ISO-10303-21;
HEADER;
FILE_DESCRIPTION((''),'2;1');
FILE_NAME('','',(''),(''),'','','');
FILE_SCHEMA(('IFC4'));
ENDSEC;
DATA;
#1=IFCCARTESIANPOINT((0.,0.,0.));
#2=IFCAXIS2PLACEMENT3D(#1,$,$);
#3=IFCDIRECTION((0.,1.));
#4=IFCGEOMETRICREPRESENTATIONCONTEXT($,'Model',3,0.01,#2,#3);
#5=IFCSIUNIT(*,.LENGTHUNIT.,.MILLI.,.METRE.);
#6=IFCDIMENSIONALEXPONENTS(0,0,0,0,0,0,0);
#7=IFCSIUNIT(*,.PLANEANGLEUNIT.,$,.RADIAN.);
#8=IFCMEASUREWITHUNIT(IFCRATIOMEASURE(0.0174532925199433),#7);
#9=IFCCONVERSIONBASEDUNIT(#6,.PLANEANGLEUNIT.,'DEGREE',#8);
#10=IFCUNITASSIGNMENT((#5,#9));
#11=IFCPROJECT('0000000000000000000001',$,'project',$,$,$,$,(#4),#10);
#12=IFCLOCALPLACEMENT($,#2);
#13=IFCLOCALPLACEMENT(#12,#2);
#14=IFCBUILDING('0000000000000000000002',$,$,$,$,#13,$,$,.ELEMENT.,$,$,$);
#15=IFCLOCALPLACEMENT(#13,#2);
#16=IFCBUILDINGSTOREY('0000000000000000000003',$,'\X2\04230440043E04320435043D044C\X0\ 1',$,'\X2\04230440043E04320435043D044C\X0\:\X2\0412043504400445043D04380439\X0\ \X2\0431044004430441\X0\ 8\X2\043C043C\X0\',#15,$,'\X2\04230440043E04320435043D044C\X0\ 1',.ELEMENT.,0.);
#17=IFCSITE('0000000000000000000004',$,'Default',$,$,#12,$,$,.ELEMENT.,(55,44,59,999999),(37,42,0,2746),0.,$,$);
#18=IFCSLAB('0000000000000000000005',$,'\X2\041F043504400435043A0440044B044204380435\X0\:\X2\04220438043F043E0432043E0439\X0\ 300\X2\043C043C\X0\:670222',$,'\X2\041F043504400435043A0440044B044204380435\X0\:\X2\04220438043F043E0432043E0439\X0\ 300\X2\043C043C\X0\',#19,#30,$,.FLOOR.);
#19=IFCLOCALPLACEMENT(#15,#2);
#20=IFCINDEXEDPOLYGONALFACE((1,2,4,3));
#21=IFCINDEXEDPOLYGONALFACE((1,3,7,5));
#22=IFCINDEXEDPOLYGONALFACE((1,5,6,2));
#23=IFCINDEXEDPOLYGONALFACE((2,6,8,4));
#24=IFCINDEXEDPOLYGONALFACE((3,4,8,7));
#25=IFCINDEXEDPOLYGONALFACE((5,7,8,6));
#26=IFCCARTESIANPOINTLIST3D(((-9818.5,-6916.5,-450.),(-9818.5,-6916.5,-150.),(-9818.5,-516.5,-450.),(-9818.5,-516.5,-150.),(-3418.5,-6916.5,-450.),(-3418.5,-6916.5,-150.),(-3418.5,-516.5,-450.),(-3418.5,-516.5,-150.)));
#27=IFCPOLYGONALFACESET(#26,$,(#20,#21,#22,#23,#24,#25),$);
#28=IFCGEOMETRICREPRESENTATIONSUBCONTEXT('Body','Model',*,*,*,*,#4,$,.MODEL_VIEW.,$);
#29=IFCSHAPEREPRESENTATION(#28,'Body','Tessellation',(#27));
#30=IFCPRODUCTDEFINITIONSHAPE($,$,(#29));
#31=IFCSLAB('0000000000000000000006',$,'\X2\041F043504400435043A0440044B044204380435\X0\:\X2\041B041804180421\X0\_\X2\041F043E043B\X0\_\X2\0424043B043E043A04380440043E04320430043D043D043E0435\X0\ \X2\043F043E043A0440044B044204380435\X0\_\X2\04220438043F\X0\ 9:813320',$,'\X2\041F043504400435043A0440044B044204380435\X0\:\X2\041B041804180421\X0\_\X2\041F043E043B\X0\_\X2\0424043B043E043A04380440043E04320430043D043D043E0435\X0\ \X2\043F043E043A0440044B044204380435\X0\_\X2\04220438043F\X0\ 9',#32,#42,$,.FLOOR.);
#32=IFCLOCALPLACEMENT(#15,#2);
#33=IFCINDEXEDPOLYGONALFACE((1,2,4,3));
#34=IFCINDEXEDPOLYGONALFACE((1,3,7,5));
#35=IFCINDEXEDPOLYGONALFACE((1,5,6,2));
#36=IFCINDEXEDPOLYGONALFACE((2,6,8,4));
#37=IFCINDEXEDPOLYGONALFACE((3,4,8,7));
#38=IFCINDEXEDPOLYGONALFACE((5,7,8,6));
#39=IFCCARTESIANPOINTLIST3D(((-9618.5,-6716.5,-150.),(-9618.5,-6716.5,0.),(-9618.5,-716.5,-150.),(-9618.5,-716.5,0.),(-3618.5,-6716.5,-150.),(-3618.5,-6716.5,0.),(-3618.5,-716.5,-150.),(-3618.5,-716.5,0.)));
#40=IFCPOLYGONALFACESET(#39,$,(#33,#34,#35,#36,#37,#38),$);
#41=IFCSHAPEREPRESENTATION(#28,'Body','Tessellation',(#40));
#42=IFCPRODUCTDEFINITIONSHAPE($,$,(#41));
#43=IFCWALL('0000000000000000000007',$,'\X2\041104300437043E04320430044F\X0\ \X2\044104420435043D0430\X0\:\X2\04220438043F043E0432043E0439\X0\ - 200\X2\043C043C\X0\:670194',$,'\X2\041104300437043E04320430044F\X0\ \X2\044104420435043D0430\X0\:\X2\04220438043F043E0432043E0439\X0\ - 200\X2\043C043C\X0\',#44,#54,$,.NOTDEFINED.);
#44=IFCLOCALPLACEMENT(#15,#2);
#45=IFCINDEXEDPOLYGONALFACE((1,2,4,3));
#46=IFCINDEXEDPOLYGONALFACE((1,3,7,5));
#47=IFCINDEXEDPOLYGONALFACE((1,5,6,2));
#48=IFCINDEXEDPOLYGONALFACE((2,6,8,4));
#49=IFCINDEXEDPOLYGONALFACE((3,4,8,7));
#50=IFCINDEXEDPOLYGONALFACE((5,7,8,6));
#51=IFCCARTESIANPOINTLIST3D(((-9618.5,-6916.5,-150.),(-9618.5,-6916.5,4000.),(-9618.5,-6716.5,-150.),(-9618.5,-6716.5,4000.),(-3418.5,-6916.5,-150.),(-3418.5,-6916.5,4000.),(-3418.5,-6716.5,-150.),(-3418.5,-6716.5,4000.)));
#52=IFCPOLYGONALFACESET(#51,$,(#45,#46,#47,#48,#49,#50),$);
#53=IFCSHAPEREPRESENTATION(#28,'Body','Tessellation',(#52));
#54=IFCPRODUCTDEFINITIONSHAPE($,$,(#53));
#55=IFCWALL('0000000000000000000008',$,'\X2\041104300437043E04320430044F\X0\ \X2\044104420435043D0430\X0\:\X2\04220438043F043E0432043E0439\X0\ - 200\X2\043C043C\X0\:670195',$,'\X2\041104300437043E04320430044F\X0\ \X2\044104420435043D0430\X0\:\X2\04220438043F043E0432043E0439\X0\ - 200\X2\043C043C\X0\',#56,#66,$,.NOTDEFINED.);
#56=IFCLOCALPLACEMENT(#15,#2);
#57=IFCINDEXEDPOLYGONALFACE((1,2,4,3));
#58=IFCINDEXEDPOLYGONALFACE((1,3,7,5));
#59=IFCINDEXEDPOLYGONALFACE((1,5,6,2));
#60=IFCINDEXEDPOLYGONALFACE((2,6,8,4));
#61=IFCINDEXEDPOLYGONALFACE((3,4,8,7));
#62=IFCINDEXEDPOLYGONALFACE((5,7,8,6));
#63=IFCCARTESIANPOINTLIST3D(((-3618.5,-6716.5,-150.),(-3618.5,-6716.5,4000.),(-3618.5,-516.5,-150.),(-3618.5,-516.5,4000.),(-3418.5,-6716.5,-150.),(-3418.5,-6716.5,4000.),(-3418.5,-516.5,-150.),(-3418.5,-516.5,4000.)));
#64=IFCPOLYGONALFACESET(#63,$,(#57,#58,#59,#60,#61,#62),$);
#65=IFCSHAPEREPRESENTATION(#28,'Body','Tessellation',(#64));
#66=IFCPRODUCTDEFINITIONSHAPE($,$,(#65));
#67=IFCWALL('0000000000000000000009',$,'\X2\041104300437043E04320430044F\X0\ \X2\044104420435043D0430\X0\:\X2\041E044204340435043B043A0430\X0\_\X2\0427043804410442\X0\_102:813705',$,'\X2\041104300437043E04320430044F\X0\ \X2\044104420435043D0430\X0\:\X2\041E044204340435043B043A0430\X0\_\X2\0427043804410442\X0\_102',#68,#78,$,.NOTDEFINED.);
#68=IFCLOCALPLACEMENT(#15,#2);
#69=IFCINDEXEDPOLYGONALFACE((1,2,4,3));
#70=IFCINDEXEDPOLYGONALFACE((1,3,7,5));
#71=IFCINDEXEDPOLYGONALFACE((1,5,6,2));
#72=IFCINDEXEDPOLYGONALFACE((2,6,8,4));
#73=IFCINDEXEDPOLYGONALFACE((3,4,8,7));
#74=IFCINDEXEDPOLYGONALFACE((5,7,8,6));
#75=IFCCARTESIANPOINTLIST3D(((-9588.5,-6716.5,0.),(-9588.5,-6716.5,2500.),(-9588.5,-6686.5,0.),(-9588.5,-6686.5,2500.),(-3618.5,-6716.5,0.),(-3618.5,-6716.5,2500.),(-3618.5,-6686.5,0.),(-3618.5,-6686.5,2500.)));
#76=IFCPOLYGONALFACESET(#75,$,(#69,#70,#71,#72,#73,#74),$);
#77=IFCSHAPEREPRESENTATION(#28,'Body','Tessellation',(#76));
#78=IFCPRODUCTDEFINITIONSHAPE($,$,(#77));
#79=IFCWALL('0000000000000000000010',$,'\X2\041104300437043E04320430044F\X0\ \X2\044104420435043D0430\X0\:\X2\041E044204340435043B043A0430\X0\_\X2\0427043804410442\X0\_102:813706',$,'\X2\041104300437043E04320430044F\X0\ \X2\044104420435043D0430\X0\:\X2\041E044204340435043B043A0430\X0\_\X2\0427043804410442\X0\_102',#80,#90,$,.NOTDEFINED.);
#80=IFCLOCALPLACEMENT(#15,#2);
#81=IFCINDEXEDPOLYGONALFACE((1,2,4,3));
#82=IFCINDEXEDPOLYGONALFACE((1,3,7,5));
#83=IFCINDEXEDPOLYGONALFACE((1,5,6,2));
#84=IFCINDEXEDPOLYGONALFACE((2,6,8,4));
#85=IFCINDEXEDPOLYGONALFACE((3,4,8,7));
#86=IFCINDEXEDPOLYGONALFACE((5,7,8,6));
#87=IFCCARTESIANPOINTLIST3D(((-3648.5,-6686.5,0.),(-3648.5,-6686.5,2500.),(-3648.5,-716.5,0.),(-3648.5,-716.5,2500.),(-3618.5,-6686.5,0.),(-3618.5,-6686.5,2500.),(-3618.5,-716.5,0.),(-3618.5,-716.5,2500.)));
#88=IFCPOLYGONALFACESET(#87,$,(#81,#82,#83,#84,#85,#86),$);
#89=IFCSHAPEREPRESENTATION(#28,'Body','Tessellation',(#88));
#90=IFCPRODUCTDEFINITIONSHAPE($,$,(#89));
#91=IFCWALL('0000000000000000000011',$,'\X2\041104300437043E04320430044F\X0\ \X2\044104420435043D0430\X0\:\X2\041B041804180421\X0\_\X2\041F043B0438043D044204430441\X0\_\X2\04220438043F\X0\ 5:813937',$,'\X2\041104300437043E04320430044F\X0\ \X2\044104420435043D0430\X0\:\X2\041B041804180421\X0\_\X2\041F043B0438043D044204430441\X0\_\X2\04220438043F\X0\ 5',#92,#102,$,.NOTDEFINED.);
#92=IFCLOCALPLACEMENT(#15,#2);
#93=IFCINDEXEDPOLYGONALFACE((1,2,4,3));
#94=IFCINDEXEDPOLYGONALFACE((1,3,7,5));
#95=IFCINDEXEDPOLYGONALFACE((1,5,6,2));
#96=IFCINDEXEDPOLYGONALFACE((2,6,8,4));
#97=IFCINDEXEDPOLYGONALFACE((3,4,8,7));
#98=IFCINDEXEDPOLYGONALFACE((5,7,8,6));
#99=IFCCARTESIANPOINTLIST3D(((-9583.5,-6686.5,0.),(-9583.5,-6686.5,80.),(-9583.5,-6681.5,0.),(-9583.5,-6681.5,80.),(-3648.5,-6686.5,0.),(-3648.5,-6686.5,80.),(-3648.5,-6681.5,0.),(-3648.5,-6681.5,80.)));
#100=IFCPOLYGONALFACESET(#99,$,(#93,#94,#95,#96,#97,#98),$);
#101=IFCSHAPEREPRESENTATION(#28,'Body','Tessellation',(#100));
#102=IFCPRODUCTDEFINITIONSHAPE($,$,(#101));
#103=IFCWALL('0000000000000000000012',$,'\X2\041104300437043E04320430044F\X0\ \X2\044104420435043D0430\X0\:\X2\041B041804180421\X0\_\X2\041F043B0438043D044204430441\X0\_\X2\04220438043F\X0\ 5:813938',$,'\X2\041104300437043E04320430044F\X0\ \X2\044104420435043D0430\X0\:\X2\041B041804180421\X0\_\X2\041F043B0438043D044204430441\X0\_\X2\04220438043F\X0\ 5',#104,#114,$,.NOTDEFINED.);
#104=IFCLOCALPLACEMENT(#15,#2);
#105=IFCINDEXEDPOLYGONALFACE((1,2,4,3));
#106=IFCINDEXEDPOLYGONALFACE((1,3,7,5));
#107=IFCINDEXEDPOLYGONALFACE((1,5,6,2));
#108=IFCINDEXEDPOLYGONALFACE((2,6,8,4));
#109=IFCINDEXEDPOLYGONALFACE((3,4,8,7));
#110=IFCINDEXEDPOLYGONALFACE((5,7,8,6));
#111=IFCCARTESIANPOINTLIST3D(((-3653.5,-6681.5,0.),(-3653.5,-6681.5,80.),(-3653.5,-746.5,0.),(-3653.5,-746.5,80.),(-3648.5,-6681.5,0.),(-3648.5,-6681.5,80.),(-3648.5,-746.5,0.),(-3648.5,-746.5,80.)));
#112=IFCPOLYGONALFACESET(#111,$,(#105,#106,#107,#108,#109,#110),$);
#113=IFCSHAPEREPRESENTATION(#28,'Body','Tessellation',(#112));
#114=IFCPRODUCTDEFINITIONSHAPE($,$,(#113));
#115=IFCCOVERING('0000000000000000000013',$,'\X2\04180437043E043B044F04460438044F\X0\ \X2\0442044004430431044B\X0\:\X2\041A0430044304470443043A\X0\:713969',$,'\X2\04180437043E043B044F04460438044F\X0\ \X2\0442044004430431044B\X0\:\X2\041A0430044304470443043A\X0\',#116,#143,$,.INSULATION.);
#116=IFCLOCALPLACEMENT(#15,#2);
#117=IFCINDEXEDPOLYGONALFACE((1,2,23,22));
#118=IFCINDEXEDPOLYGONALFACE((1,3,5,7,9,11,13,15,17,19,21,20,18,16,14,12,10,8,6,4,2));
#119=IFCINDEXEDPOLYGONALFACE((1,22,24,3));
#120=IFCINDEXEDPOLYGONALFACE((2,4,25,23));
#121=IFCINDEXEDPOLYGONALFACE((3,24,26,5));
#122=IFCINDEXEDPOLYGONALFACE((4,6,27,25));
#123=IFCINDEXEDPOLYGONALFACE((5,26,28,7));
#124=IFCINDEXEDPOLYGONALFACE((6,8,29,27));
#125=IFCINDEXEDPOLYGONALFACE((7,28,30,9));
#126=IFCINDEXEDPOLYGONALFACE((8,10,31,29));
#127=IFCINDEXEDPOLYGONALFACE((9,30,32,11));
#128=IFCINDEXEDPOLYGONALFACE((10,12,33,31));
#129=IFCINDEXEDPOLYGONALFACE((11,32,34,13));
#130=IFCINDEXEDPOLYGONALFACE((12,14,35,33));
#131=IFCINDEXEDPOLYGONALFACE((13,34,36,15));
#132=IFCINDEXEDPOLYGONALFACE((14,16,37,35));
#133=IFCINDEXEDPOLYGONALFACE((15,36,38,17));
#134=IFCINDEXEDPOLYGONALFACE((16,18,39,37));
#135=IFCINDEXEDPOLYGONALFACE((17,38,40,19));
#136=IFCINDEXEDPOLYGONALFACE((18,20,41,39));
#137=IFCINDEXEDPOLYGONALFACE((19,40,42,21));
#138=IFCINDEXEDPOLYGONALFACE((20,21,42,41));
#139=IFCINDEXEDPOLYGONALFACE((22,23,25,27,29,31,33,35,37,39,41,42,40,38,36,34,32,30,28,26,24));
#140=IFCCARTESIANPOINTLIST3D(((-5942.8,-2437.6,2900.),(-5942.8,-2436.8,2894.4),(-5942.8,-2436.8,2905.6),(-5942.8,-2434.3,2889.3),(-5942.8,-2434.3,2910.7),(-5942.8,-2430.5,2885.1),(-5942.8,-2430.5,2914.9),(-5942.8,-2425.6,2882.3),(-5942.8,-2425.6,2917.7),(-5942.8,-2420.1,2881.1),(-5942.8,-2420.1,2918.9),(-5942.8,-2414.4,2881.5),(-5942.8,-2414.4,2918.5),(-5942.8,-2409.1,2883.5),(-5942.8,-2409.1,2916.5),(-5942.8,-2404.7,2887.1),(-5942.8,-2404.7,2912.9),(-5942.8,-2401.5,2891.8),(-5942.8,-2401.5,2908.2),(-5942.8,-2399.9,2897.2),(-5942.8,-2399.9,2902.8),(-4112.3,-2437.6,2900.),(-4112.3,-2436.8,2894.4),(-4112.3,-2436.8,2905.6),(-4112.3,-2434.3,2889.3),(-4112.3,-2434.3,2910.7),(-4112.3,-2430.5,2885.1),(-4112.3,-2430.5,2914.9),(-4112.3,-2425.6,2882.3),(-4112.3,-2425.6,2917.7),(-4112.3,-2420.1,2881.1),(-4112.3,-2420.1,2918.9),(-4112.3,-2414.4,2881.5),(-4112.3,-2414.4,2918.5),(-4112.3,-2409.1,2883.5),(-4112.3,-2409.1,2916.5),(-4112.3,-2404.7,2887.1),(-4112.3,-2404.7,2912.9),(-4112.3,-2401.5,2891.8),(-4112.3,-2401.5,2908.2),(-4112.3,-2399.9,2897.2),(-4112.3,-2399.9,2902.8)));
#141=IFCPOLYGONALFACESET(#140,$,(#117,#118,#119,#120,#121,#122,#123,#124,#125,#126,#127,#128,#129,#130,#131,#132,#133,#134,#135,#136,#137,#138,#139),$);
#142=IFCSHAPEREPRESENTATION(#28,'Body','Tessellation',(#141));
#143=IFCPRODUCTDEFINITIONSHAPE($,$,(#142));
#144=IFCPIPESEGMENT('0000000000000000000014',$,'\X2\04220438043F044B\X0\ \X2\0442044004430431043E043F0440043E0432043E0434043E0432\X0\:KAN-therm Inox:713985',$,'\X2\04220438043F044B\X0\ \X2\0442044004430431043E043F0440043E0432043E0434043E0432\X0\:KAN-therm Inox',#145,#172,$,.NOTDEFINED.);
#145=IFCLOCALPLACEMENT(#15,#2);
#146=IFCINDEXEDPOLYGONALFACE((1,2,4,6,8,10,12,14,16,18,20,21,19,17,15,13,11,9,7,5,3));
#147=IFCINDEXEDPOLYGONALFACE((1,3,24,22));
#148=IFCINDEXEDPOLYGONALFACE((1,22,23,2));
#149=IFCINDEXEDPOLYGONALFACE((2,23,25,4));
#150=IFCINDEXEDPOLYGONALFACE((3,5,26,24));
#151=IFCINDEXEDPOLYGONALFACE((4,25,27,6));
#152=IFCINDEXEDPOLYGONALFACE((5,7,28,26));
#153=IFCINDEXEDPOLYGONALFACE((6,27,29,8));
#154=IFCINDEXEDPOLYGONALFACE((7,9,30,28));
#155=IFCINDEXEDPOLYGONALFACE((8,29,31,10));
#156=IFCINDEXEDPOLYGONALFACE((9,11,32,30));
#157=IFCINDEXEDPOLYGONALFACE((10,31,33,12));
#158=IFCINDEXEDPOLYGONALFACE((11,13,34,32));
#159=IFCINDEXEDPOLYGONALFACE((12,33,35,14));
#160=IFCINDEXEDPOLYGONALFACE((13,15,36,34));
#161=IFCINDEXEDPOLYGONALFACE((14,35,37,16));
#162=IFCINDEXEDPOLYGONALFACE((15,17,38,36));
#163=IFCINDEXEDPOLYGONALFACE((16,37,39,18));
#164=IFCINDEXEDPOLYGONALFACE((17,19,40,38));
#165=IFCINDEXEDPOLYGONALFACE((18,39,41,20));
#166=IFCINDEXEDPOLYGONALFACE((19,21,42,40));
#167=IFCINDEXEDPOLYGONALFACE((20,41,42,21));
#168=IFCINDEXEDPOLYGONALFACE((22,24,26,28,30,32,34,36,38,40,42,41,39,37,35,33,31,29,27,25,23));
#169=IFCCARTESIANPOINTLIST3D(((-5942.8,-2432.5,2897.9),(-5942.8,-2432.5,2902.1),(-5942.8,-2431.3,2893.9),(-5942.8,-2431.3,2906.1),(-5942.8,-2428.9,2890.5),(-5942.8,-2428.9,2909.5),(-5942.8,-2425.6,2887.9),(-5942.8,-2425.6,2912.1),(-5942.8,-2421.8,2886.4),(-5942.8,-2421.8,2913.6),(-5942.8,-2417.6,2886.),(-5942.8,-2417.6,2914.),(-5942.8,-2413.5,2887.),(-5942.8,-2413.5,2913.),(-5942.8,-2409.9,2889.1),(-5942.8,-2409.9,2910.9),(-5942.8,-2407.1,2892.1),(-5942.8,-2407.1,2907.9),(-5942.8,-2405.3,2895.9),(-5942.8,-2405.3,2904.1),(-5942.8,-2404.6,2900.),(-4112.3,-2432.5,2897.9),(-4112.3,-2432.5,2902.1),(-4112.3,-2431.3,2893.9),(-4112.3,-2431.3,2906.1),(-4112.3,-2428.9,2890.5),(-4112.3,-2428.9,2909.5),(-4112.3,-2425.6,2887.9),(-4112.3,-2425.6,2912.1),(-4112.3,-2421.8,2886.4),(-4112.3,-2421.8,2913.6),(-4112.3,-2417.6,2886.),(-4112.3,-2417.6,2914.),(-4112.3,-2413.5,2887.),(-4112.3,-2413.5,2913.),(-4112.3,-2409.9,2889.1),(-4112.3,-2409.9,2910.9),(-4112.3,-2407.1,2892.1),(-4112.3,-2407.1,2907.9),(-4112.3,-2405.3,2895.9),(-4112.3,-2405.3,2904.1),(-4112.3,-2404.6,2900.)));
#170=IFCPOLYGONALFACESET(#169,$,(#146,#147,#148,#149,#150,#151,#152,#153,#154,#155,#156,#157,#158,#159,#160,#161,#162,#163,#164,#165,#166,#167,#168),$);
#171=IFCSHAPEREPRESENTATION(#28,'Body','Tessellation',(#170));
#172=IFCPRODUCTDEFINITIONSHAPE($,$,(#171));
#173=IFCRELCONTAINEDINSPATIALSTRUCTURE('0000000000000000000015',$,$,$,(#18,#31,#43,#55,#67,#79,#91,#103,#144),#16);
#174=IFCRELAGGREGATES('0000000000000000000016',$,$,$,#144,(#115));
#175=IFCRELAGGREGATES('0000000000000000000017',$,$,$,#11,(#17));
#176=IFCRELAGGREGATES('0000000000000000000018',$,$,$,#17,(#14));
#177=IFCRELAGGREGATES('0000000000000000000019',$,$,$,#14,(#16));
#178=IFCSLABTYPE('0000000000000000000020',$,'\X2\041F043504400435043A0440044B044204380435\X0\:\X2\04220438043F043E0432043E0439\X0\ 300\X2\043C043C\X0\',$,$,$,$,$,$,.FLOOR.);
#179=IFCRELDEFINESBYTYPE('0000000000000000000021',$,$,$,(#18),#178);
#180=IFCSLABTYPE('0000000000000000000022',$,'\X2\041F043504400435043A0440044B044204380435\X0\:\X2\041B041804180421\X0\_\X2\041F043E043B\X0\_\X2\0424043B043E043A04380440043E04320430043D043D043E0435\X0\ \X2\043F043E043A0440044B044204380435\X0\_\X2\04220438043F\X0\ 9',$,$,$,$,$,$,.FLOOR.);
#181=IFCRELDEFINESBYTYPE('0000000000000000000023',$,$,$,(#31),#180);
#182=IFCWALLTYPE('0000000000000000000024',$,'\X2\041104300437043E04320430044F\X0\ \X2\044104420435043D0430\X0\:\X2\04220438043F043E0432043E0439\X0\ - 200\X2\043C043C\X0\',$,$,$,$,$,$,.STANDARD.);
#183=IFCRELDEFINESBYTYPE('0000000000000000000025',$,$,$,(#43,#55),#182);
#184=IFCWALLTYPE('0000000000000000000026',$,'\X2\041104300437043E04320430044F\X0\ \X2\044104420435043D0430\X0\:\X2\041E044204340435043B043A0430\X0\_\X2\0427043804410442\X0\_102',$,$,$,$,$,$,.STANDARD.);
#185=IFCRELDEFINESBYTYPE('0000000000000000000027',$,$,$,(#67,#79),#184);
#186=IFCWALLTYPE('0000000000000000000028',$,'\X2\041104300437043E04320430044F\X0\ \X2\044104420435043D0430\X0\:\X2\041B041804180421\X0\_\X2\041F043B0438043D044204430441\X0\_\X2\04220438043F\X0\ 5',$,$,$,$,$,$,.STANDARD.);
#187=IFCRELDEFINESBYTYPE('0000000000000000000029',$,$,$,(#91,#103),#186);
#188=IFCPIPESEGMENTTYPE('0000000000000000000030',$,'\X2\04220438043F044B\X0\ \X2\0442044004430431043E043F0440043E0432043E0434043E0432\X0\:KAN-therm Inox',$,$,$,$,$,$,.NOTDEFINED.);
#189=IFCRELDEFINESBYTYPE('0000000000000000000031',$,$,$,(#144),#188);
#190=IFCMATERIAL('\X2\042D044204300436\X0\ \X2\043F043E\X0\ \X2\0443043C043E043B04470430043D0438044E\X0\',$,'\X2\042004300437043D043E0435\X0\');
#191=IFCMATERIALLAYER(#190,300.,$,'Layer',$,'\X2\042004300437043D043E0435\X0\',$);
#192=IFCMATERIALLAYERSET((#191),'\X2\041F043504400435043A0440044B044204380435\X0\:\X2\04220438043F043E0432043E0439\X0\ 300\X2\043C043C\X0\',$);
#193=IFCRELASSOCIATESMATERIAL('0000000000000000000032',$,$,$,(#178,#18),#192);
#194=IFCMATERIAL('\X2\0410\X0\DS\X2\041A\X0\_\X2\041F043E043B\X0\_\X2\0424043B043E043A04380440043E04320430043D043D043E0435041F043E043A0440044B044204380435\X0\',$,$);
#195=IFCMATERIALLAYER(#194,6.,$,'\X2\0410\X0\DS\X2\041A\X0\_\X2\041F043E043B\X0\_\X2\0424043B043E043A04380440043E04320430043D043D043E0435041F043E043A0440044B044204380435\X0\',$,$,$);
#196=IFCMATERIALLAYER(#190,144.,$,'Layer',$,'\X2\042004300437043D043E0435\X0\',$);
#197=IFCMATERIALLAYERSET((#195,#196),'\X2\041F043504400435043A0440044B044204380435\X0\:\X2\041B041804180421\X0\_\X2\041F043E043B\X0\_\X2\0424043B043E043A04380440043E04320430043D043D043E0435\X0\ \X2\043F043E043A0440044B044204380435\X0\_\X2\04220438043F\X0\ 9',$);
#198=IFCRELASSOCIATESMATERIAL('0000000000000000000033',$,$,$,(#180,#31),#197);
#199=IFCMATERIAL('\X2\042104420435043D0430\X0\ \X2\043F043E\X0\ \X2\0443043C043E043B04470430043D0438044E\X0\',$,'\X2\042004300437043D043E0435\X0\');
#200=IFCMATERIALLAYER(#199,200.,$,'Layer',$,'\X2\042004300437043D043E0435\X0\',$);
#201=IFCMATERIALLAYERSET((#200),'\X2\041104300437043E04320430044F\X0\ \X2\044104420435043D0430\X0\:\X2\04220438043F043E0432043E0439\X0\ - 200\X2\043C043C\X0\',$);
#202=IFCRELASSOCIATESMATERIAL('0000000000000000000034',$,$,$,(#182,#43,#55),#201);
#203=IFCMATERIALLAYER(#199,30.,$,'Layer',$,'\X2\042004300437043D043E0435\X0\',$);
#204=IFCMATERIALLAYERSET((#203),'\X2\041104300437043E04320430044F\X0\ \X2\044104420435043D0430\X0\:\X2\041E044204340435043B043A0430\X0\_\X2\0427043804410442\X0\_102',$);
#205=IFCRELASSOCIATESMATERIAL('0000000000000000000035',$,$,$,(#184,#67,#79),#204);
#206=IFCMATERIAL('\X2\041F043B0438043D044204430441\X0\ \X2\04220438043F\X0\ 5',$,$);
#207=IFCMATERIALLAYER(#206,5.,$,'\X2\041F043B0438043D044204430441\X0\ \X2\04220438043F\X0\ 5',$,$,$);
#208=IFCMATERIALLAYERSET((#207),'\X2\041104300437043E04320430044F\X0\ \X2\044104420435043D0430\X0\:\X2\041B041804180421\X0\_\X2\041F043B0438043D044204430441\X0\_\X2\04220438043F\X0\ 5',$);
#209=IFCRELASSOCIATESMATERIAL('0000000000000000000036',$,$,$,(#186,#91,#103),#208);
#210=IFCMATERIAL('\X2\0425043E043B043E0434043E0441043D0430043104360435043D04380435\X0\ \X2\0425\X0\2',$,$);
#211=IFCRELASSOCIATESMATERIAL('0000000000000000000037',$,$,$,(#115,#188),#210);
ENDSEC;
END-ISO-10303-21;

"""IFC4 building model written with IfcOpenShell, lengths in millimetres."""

from ifc_helpers import new_model, entity, si_unit, converted_unit, direction, frame, frame_2d, origin, origin_2d_with_axis, place, context, subcontext, project, spatial, rectangle, circle, extrude, material, layer, layer_set, layer_usage, type_object, element, aggregate, save


model = new_model("IFC4")

# Units and contexts
model_context = context("Model", 3, precision=0.01, world=origin(), true_north=direction((0.0, 1.0)))
body_context = subcontext(model_context, "Body", "Model", "MODEL_VIEW")
ifc_project = project(units=[si_unit("LENGTHUNIT", "METRE", prefix="MILLI"), converted_unit("PLANEANGLEUNIT", "DEGREE", entity("IfcRatioMeasure", 0.0174532925199433), si_unit("PLANEANGLEUNIT", "RADIAN"), dimensions=[0, 0, 0, 0, 0, 0, 0])], contexts=[model_context])

# Site, building, storey
site_placement = place(None, origin())
site = spatial("IfcSite", under=ifc_project, at=site_placement, Name="Default", CompositionType="ELEMENT", RefLatitude=(55, 44, 59, 999999), RefLongitude=(37, 42, 0, 2746), RefElevation=0.0)
building_placement = place(site_placement, origin())
building = spatial("IfcBuilding", under=site, at=building_placement, CompositionType="ELEMENT")
storey_placement = place(building_placement, origin())
storey = spatial("IfcBuildingStorey", under=building, at=storey_placement, Name="Уровень 1", ObjectType="Уровень:Верхний брус 8мм", LongName="Уровень 1", CompositionType="ELEMENT", Elevation=0.0)

# Slabs
ifc_material_1 = material(Name="Этаж по умолчанию", Category="Разное")
ifc_layer_1 = layer(ifc_material_1, 300.0, Name="Layer", Category="Разное")
ifc_layer_set_1 = layer_set([ifc_layer_1], Name="Перекрытие:Типовой 300мм")
ifc_layer_usage_1 = layer_usage(ifc_layer_set_1, "AXIS3", "POSITIVE", 0.0)
slab_type_1 = type_object("IfcSlabType", Name="Перекрытие:Типовой 300мм", PredefinedType="FLOOR", material=ifc_layer_set_1)
slab_1_placement = place(storey_placement, origin())
element("IfcSlab", 1, at=slab_1_placement, inside=storey, type_object=slab_type_1, material=ifc_layer_usage_1, Name="Перекрытие:Типовой 300мм:670222", ObjectType="Перекрытие:Типовой 300мм", PredefinedType="FLOOR", context=body_context, shape_type="SweptSolid", body=[
    extrude(rectangle(XDim=6400.0, YDim=6400.0, at=origin_2d_with_axis()), frame((-6618.5, -3716.5, -150.0), z_axis=(0.0, 0.0, -1.0), x_axis=(0.0, 1.0, 0.0)), (0.0, 0.0, 1.0), 300.0),
])
ifc_material_2 = material(Name="АDSК_Пол_ФлокированноеПокрытие")
ifc_layer_2 = layer(ifc_material_2, 6.0, Name="АDSК_Пол_ФлокированноеПокрытие")
ifc_layer_3 = layer(ifc_material_1, 144.0, Name="Layer", Category="Разное")
ifc_layer_set_2 = layer_set([ifc_layer_2, ifc_layer_3], Name="Перекрытие:ЛИИС_Пол_Флокированное покрытие_Тип 9")
ifc_layer_usage_2 = layer_usage(ifc_layer_set_2, "AXIS3", "POSITIVE", 0.0)
slab_type_2 = type_object("IfcSlabType", Name="Перекрытие:ЛИИС_Пол_Флокированное покрытие_Тип 9", PredefinedType="FLOOR", material=ifc_layer_set_2)
slab_2_placement = place(storey_placement, origin())
element("IfcSlab", 2, at=slab_2_placement, inside=storey, type_object=slab_type_2, material=ifc_layer_usage_2, Name="Перекрытие:ЛИИС_Пол_Флокированное покрытие_Тип 9:813320", ObjectType="Перекрытие:ЛИИС_Пол_Флокированное покрытие_Тип 9", PredefinedType="FLOOR", context=body_context, shape_type="SweptSolid", body=[
    extrude(rectangle(XDim=6000.0, YDim=6000.0, at=origin_2d_with_axis()), frame((-6618.5, -3716.5, 0.0), z_axis=(0.0, 0.0, -1.0), x_axis=(0.0, 1.0, 0.0)), (0.0, 0.0, 1.0), 150.0),
])

# Walls
ifc_material_3 = material(Name="Стена по умолчанию", Category="Разное")
ifc_layer_4 = layer(ifc_material_3, 200.0, Name="Layer", Category="Разное")
ifc_layer_set_3 = layer_set([ifc_layer_4], Name="Базовая стена:Типовой - 200мм")
ifc_layer_usage_3 = layer_usage(ifc_layer_set_3, "AXIS2", "NEGATIVE", 100.0)
wall_type_1 = type_object("IfcWallType", Name="Базовая стена:Типовой - 200мм", PredefinedType="STANDARD", material=ifc_layer_set_3)
wall_1_placement = place(storey_placement, frame((-3418.5, -6816.5, -150.0), z_axis=(0.0, 0.0, 1.0), x_axis=(-1.0, 0.0, 0.0)))
element("IfcWall", 3, at=wall_1_placement, inside=storey, type_object=wall_type_1, material=ifc_layer_usage_3, Name="Базовая стена:Типовой - 200мм:670194", ObjectType="Базовая стена:Типовой - 200мм", PredefinedType="NOTDEFINED", context=body_context, shape_type="SweptSolid", body=[
    extrude(rectangle(XDim=6200.0, YDim=200.0, at=frame_2d((3100.0, 0.0), x_axis=(-1.0, 0.0))), origin(), (0.0, 0.0, 1.0), 4150.0),
])
ifc_layer_usage_4 = layer_usage(ifc_layer_set_3, "AXIS2", "NEGATIVE", 100.0)
wall_2_placement = place(storey_placement, frame((-3518.5, -516.5, -150.0), z_axis=(0.0, 0.0, 1.0), x_axis=(0.0, -1.0, 0.0)))
element("IfcWall", 4, at=wall_2_placement, inside=storey, type_object=wall_type_1, material=ifc_layer_usage_4, Name="Базовая стена:Типовой - 200мм:670195", ObjectType="Базовая стена:Типовой - 200мм", PredefinedType="NOTDEFINED", context=body_context, shape_type="SweptSolid", body=[
    extrude(rectangle(XDim=6200.0, YDim=200.0, at=frame_2d((3100.0, 0.0), x_axis=(-1.0, 0.0))), origin(), (0.0, 0.0, 1.0), 4150.0),
])
ifc_layer_5 = layer(ifc_material_3, 30.0, Name="Layer", Category="Разное")
ifc_layer_set_4 = layer_set([ifc_layer_5], Name="Базовая стена:Отделка_Чист_102")
ifc_layer_usage_5 = layer_usage(ifc_layer_set_4, "AXIS2", "POSITIVE", -15.0)
wall_type_2 = type_object("IfcWallType", Name="Базовая стена:Отделка_Чист_102", PredefinedType="STANDARD", material=ifc_layer_set_4)
wall_3_placement = place(storey_placement, frame((-3618.5, -6701.5, 0.0), z_axis=(0.0, 0.0, 1.0), x_axis=(-1.0, 0.0, 0.0)))
element("IfcWall", 5, at=wall_3_placement, inside=storey, type_object=wall_type_2, material=ifc_layer_usage_5, Name="Базовая стена:Отделка_Чист_102:813705", ObjectType="Базовая стена:Отделка_Чист_102", PredefinedType="NOTDEFINED", context=body_context, shape_type="SweptSolid", body=[
    extrude(rectangle(XDim=5970.0, YDim=30.0, at=frame_2d((2985.0, 0.0), x_axis=(-1.0, 0.0))), origin(), (0.0, 0.0, 1.0), 2500.0),
])
ifc_layer_usage_6 = layer_usage(ifc_layer_set_4, "AXIS2", "POSITIVE", -15.0)
wall_4_placement = place(storey_placement, frame((-3633.5, -716.5, 0.0), z_axis=(0.0, 0.0, 1.0), x_axis=(0.0, -1.0, 0.0)))
element("IfcWall", 6, at=wall_4_placement, inside=storey, type_object=wall_type_2, material=ifc_layer_usage_6, Name="Базовая стена:Отделка_Чист_102:813706", ObjectType="Базовая стена:Отделка_Чист_102", PredefinedType="NOTDEFINED", context=body_context, shape_type="SweptSolid", body=[
    extrude(rectangle(XDim=5970.0, YDim=30.0, at=frame_2d((2985.0, 0.0), x_axis=(-1.0, 0.0))), origin(), (0.0, 0.0, 1.0), 2500.0),
])
ifc_material_4 = material(Name="Плинтус Тип 5")
ifc_layer_6 = layer(ifc_material_4, 5.0, Name="Плинтус Тип 5")
ifc_layer_set_5 = layer_set([ifc_layer_6], Name="Базовая стена:ЛИИС_Плинтус_Тип 5")
ifc_layer_usage_7 = layer_usage(ifc_layer_set_5, "AXIS2", "NEGATIVE", 2.5)
wall_type_3 = type_object("IfcWallType", Name="Базовая стена:ЛИИС_Плинтус_Тип 5", PredefinedType="STANDARD", material=ifc_layer_set_5)
wall_5_placement = place(storey_placement, frame((-3648.5, -6684.0, 0.0), z_axis=(0.0, 0.0, 1.0), x_axis=(-1.0, 0.0, 0.0)))
element("IfcWall", 7, at=wall_5_placement, inside=storey, type_object=wall_type_3, material=ifc_layer_usage_7, Name="Базовая стена:ЛИИС_Плинтус_Тип 5:813937", ObjectType="Базовая стена:ЛИИС_Плинтус_Тип 5", PredefinedType="NOTDEFINED", context=body_context, shape_type="SweptSolid", body=[
    extrude(rectangle(XDim=5935.0, YDim=5.0, at=frame_2d((2967.5, 0.0), x_axis=(-1.0, 0.0))), origin(), (0.0, 0.0, 1.0), 80.0),
])
ifc_layer_usage_8 = layer_usage(ifc_layer_set_5, "AXIS2", "NEGATIVE", 2.5)
wall_6_placement = place(storey_placement, frame((-3651.0, -746.5, 0.0), z_axis=(0.0, 0.0, 1.0), x_axis=(0.0, -1.0, 0.0)))
element("IfcWall", 8, at=wall_6_placement, inside=storey, type_object=wall_type_3, material=ifc_layer_usage_8, Name="Базовая стена:ЛИИС_Плинтус_Тип 5:813938", ObjectType="Базовая стена:ЛИИС_Плинтус_Тип 5", PredefinedType="NOTDEFINED", context=body_context, shape_type="SweptSolid", body=[
    extrude(rectangle(XDim=5935.0, YDim=5.0, at=frame_2d((2967.5, 0.0), x_axis=(-1.0, 0.0))), origin(), (0.0, 0.0, 1.0), 80.0),
])

# Covering
ifc_material_5 = material(Name="Холодоснабжение Х2")
covering_1_placement = place(storey_placement, frame((-5942.8, -2439.2, 2879.4)))
covering_1 = element("IfcCovering", 9, at=covering_1_placement, material=ifc_material_5, Name="Изоляция трубы:Каучук:713969", ObjectType="Изоляция трубы:Каучук", PredefinedType="INSULATION", context=body_context, shape_type="SweptSolid", body=[
    extrude(circle(Radius=19.0, at=frame_2d((0.0, 0.0), x_axis=(1.0, 0.0))), frame((0.0, 20.6, 20.6), z_axis=(1.0, 0.0, 0.0), x_axis=(0.0, -1.0, 0.0)), (0.0, 0.0, 1.0), 1830.4),
])

# Pipe segment
pipe_segment_type_1 = type_object("IfcPipeSegmentType", Name="Типы трубопроводов:KAN-therm Inox", PredefinedType="NOTDEFINED", material=ifc_material_5)
pipe_segment_1_placement = place(storey_placement, frame((-5942.8, -2434.2, 2884.4)))
pipe_segment_1 = element("IfcPipeSegment", 10, at=pipe_segment_1_placement, inside=storey, type_object=pipe_segment_type_1, Name="Типы трубопроводов:KAN-therm Inox:713985", ObjectType="Типы трубопроводов:KAN-therm Inox", PredefinedType="NOTDEFINED", context=body_context, shape_type="SweptSolid", body=[
    extrude(circle(Radius=14.0, at=frame_2d((0.0, 0.0), x_axis=(1.0, 0.0))), frame((0.0, 15.6, 15.6), z_axis=(1.0, 0.0, 0.0), x_axis=(0.0, 1.0, 0.0)), (0.0, 0.0, 1.0), 1830.4),
])
aggregate(pipe_segment_1, [covering_1])

save(model, "model.ifc")
